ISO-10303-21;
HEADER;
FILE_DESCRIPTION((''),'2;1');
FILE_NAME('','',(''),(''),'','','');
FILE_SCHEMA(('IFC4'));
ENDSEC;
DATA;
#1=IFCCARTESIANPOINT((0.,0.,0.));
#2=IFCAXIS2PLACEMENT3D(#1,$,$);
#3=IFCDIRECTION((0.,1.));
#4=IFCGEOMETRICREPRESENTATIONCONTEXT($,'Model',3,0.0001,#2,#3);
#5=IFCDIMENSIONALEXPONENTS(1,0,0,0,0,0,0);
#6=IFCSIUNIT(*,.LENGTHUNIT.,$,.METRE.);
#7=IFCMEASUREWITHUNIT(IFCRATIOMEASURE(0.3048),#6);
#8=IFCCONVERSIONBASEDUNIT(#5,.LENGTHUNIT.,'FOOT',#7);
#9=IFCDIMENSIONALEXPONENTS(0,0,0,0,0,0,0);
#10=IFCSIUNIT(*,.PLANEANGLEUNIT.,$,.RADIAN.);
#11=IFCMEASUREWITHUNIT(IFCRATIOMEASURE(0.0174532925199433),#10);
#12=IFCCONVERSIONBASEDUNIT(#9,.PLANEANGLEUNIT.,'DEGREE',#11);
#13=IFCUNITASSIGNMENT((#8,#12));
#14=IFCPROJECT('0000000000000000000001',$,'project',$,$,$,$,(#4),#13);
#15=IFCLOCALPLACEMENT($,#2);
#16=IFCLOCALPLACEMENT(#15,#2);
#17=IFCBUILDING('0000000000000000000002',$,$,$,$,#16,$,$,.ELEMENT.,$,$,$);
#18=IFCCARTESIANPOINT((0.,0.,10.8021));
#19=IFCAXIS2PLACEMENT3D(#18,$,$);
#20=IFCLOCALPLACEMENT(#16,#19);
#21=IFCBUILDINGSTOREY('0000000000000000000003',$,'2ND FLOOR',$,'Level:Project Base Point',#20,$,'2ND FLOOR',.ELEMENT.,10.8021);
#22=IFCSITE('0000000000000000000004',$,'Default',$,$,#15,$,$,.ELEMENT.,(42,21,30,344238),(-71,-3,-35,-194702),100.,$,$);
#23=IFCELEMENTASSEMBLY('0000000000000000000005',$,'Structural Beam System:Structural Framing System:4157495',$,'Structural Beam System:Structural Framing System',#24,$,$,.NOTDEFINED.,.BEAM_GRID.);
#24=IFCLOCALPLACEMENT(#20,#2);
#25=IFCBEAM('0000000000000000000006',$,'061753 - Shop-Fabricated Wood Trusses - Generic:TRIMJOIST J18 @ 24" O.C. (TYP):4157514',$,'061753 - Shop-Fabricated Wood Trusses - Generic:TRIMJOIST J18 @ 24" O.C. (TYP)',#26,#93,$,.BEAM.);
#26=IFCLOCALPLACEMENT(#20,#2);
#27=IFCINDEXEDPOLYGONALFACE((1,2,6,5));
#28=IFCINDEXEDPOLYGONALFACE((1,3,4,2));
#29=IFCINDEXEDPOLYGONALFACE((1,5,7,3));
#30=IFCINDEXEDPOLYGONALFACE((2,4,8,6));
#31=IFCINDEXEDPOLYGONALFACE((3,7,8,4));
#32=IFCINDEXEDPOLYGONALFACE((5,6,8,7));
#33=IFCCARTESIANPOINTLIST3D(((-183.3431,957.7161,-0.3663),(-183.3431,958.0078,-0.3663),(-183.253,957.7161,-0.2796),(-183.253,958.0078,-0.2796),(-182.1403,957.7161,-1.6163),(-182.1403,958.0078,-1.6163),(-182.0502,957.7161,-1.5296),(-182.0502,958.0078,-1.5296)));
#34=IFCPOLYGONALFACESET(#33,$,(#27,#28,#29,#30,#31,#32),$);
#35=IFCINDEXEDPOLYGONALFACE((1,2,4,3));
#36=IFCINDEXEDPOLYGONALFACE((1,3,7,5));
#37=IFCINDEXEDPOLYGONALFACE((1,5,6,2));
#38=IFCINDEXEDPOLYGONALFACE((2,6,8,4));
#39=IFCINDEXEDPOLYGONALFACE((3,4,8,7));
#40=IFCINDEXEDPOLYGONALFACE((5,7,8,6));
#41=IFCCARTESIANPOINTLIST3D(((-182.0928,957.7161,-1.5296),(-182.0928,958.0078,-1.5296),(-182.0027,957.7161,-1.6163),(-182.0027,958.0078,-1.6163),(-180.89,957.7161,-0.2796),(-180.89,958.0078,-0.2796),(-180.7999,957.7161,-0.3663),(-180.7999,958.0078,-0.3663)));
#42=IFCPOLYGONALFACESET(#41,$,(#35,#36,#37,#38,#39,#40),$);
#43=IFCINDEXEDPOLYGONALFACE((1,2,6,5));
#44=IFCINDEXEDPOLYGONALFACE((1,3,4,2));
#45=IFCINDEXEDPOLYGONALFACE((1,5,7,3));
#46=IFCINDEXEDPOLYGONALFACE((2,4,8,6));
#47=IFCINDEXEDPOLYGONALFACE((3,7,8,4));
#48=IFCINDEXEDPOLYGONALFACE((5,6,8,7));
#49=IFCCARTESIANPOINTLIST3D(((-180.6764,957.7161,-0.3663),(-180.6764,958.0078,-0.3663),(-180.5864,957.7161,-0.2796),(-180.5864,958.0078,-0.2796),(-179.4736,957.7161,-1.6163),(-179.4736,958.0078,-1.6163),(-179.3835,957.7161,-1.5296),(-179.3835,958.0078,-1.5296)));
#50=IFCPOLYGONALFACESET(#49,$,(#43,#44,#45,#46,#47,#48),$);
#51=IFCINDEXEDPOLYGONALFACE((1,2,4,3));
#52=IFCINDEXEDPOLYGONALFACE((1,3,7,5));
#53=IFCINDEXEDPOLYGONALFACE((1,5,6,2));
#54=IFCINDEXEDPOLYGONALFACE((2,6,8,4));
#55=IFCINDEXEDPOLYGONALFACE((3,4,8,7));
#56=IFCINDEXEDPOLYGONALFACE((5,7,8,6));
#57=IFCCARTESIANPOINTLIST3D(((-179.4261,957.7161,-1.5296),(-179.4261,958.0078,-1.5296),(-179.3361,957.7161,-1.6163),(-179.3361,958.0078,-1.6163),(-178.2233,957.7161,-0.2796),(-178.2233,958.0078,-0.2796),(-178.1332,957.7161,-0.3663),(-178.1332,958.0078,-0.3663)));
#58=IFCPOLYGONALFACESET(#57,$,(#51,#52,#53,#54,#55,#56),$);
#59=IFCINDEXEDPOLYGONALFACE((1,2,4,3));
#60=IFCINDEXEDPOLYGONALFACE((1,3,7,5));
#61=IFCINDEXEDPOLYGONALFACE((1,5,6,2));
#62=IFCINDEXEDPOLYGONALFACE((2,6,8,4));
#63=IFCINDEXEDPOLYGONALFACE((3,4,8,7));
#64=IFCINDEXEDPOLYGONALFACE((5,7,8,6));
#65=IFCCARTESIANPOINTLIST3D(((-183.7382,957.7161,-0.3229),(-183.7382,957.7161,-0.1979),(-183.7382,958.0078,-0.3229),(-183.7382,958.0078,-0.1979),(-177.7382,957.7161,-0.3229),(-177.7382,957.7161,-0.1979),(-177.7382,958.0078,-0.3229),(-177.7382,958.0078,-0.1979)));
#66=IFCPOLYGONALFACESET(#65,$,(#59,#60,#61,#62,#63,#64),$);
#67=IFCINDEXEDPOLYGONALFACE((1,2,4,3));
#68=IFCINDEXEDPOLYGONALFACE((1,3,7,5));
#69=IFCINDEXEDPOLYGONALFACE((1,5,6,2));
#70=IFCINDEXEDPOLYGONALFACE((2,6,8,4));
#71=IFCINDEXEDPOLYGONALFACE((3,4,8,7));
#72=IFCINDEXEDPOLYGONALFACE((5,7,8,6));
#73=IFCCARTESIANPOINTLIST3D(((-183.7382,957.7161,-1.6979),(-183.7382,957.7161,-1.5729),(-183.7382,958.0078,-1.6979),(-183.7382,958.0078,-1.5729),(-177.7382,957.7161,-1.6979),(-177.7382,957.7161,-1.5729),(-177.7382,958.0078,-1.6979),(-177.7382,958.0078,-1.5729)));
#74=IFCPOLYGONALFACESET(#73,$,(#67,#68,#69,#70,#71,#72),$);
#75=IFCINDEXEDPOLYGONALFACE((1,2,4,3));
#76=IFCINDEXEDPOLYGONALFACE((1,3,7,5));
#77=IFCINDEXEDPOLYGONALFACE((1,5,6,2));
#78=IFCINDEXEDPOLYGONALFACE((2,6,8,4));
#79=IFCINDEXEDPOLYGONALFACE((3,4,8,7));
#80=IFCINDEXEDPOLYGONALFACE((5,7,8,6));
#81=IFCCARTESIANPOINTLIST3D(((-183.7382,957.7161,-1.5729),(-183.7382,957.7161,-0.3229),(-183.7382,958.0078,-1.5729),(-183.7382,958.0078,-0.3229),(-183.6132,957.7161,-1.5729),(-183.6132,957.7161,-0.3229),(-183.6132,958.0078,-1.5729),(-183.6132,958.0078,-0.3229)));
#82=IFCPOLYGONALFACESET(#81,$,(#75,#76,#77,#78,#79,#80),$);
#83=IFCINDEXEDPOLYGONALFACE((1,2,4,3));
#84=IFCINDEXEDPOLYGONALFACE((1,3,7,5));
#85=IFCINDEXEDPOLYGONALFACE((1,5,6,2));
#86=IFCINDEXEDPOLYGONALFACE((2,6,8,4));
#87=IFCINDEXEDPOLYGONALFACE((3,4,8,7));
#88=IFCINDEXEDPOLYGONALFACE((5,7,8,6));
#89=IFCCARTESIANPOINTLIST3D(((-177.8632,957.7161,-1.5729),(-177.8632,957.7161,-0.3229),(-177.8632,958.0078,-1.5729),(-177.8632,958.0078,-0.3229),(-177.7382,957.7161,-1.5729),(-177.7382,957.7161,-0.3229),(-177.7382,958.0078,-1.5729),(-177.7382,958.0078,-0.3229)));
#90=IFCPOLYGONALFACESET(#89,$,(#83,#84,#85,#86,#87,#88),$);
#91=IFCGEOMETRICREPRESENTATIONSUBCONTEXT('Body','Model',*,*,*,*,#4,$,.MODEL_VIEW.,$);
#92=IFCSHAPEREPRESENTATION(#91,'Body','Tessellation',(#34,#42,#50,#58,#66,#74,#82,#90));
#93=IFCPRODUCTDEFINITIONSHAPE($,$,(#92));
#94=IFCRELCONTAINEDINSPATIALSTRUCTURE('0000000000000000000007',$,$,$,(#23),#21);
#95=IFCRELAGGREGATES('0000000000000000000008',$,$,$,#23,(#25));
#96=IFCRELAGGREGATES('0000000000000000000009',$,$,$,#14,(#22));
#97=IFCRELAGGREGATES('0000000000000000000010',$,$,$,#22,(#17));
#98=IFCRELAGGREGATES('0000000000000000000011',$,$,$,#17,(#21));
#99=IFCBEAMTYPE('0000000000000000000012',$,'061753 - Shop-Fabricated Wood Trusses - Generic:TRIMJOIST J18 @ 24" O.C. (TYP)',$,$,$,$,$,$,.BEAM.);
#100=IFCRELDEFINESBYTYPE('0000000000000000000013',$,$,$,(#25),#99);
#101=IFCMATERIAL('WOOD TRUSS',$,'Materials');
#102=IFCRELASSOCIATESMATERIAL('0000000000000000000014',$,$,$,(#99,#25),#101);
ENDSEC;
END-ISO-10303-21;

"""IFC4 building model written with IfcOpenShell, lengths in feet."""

from ifc_helpers import new_model, entity, si_unit, converted_unit, direction, frame, frame_2d, origin, origin_2d_with_axis, place, context, subcontext, project, spatial, rectangle, extrude, source, transform, mapped, material, material_profile, profile_set, profile_usage, type_object, type_shapes, element, aggregate, save


model = new_model("IFC4")

# Units and contexts
model_context = context("Model", 3, precision=0.0001, world=origin(), true_north=direction((0.0, 1.0)))
body_context = subcontext(model_context, "Body", "Model", "MODEL_VIEW")
ifc_project = project(units=[converted_unit("LENGTHUNIT", "FOOT", entity("IfcRatioMeasure", 0.3048), si_unit("LENGTHUNIT", "METRE"), dimensions=[1, 0, 0, 0, 0, 0, 0]), converted_unit("PLANEANGLEUNIT", "DEGREE", entity("IfcRatioMeasure", 0.0174532925199433), si_unit("PLANEANGLEUNIT", "RADIAN"), dimensions=[0, 0, 0, 0, 0, 0, 0])], contexts=[model_context])

# Site, building, storey
site_placement = place(None, origin())
site = spatial("IfcSite", under=ifc_project, at=site_placement, Name="Default", CompositionType="ELEMENT", RefLatitude=(42, 21, 30, 344238), RefLongitude=(-71, -3, -35, -194702), RefElevation=100.0)
building_placement = place(site_placement, origin())
building = spatial("IfcBuilding", under=site, at=building_placement, CompositionType="ELEMENT")
storey_placement = place(building_placement, frame((0.0, 0.0, 10.8021)))
storey = spatial("IfcBuildingStorey", under=building, at=storey_placement, Name="2ND FLOOR", ObjectType="Level:Project Base Point", LongName="2ND FLOOR", CompositionType="ELEMENT", Elevation=10.8021)

# Element assembly, beam
assembly_1_placement = place(storey_placement, origin())
assembly_1 = element("IfcElementAssembly", 1, at=assembly_1_placement, inside=storey, Name="Structural Beam System:Structural Framing System:4157495", ObjectType="Structural Beam System:Structural Framing System", AssemblyPlace="NOTDEFINED", PredefinedType="BEAM_GRID")
ifc_material_1 = material(Name="WOOD TRUSS", Category="Materials")
ifc_material_profile_1 = material_profile(ifc_material_1, rectangle(XDim=1.7347, YDim=0.125, at=frame_2d((0.0, 0.0), x_axis=(1.0, 0.0))), Name="TRIMJOIST J18 @ 24\" O.C. (TYP)")
ifc_material_profile_2 = material_profile(ifc_material_1, rectangle(XDim=1.7347, YDim=0.125, at=frame_2d((0.0, 0.0), x_axis=(1.0, 0.0))), Name="TRIMJOIST J18 @ 24\" O.C. (TYP)")
ifc_material_profile_3 = material_profile(ifc_material_1, rectangle(XDim=1.7347, YDim=0.125, at=frame_2d((0.0, 0.0), x_axis=(1.0, 0.0))), Name="TRIMJOIST J18 @ 24\" O.C. (TYP)")
ifc_material_profile_4 = material_profile(ifc_material_1, rectangle(XDim=1.7347, YDim=0.125, at=frame_2d((0.0, 0.0), x_axis=(1.0, 0.0))), Name="TRIMJOIST J18 @ 24\" O.C. (TYP)")
ifc_material_profile_5 = material_profile(ifc_material_1, rectangle(XDim=1.7347, YDim=0.125, at=frame_2d((0.0, 0.0), x_axis=(1.0, 0.0))), Name="TRIMJOIST J18 @ 24\" O.C. (TYP)")
ifc_material_profile_6 = material_profile(ifc_material_1, rectangle(XDim=1.7347, YDim=0.125, at=frame_2d((0.0, 0.0), x_axis=(1.0, 0.0))), Name="TRIMJOIST J18 @ 24\" O.C. (TYP)")
ifc_material_profile_7 = material_profile(ifc_material_1, rectangle(XDim=1.7347, YDim=0.125, at=frame_2d((0.0, 0.0), x_axis=(1.0, 0.0))), Name="TRIMJOIST J18 @ 24\" O.C. (TYP)")
ifc_material_profile_8 = material_profile(ifc_material_1, rectangle(XDim=1.7347, YDim=0.125, at=frame_2d((0.0, 0.0), x_axis=(1.0, 0.0))), Name="TRIMJOIST J18 @ 24\" O.C. (TYP)")
ifc_material_profile_9 = material_profile(ifc_material_1, rectangle(XDim=1.7347, YDim=0.125, at=frame_2d((0.0, 0.0), x_axis=(1.0, 0.0))), Name="TRIMJOIST J18 @ 24\" O.C. (TYP)")
ifc_material_profile_10 = material_profile(ifc_material_1, rectangle(XDim=1.7347, YDim=0.125, at=origin_2d_with_axis()), Name="TRIMJOIST J18 @ 24\" O.C. (TYP)")
ifc_material_profile_11 = material_profile(ifc_material_1, rectangle(XDim=0.125, YDim=0.2917, at=origin_2d_with_axis()), Name="TRIMJOIST J18 @ 24\" O.C. (TYP)")
ifc_material_profile_12 = material_profile(ifc_material_1, rectangle(XDim=0.125, YDim=0.2917, at=origin_2d_with_axis()), Name="TRIMJOIST J18 @ 24\" O.C. (TYP)")
ifc_material_profile_13 = material_profile(ifc_material_1, rectangle(XDim=1.25, YDim=0.2917, at=origin_2d_with_axis()), Name="TRIMJOIST J18 @ 24\" O.C. (TYP)")
ifc_material_profile_14 = material_profile(ifc_material_1, rectangle(XDim=1.25, YDim=0.2917, at=origin_2d_with_axis()), Name="TRIMJOIST J18 @ 24\" O.C. (TYP)")
ifc_profile_set_1 = profile_set([ifc_material_profile_1, ifc_material_profile_2, ifc_material_profile_3, ifc_material_profile_4, ifc_material_profile_5, ifc_material_profile_6, ifc_material_profile_7, ifc_material_profile_8, ifc_material_profile_9, ifc_material_profile_10, ifc_material_profile_11, ifc_material_profile_12, ifc_material_profile_13, ifc_material_profile_14], Name="TRIMJOIST J18 @ 24\" O.C. (TYP)")
ifc_profile_usage_1 = profile_usage(ifc_profile_set_1, cardinal=8)
beam_type_1 = type_object("IfcBeamType", Name="061753 - Shop-Fabricated Wood Trusses - Generic:TRIMJOIST J18 @ 24\" O.C. (TYP)", PredefinedType="BEAM", material=ifc_profile_set_1)
shared_shape_1 = source(origin(), body_context, "Body", "SweptSolid", [
    extrude(rectangle(XDim=1.7347, YDim=0.125, at=frame_2d((0.0, 0.0), x_axis=(1.0, 0.0))), frame((1.9585, -0.1458, 0.0), z_axis=(0.0, 1.0, 0.0), x_axis=(0.693383, 0.0, 0.720569)), (0.0, 0.0, 1.0), 0.2917),
    extrude(rectangle(XDim=1.7347, YDim=0.125, at=frame_2d((0.0, 0.0), x_axis=(1.0, 0.0))), frame((0.7082, -0.1458, 0.0), z_axis=(0.0, 1.0, 0.0), x_axis=(0.693383, 0.0, -0.720569)), (0.0, 0.0, 1.0), 0.2917),
    extrude(rectangle(XDim=1.7347, YDim=0.125, at=frame_2d((0.0, 0.0), x_axis=(1.0, 0.0))), frame((-0.7082, -0.1458, 0.0), z_axis=(0.0, 1.0, 0.0), x_axis=(0.693383, 0.0, 0.720569)), (0.0, 0.0, 1.0), 0.2917),
    extrude(rectangle(XDim=1.7347, YDim=0.125, at=frame_2d((0.0, 0.0), x_axis=(1.0, 0.0))), frame((-1.9585, -0.1458, 0.0), z_axis=(0.0, 1.0, 0.0), x_axis=(0.693383, 0.0, -0.720569)), (0.0, 0.0, 1.0), 0.2917),
    extrude(rectangle(XDim=0.125, YDim=0.2917, at=origin_2d_with_axis()), frame((-3.0, 0.0, 0.6875), z_axis=(1.0, 0.0, 0.0), x_axis=(0.0, 0.0, -1.0)), (0.0, 0.0, 1.0), 6.0),
    extrude(rectangle(XDim=0.125, YDim=0.2917, at=origin_2d_with_axis()), frame((-3.0, 0.0, -0.6875), z_axis=(1.0, 0.0, 0.0), x_axis=(0.0, 0.0, -1.0)), (0.0, 0.0, 1.0), 6.0),
    extrude(rectangle(XDim=1.25, YDim=0.2917, at=origin_2d_with_axis()), frame((2.875, 0.0, 0.0), z_axis=(1.0, 0.0, 0.0), x_axis=(0.0, 0.0, -1.0)), (0.0, 0.0, 1.0), 0.125),
    extrude(rectangle(XDim=1.25, YDim=0.2917, at=origin_2d_with_axis()), frame((-3.0, 0.0, 0.0), z_axis=(1.0, 0.0, 0.0), x_axis=(0.0, 0.0, -1.0)), (0.0, 0.0, 1.0), 0.125),
])
type_shapes(beam_type_1, [shared_shape_1])
beam_1_placement = place(assembly_1_placement, frame((-180.7382, 957.8619, -0.9479), z_axis=(0.0, 0.0, 1.0), x_axis=(-1.0, 0.0, 0.0)))
beam_1 = element("IfcBeam", 2, at=beam_1_placement, type_object=beam_type_1, material=ifc_profile_usage_1, Name="061753 - Shop-Fabricated Wood Trusses - Generic:TRIMJOIST J18 @ 24\" O.C. (TYP):4157514", ObjectType="061753 - Shop-Fabricated Wood Trusses - Generic:TRIMJOIST J18 @ 24\" O.C. (TYP)", PredefinedType="BEAM", context=body_context, shape_type="MappedRepresentation", body=[
    mapped(shared_shape_1, transform((0.0, 0.0, 0.0), scale=1.0)),
])
aggregate(assembly_1, [beam_1])

save(model, "model.ifc")
